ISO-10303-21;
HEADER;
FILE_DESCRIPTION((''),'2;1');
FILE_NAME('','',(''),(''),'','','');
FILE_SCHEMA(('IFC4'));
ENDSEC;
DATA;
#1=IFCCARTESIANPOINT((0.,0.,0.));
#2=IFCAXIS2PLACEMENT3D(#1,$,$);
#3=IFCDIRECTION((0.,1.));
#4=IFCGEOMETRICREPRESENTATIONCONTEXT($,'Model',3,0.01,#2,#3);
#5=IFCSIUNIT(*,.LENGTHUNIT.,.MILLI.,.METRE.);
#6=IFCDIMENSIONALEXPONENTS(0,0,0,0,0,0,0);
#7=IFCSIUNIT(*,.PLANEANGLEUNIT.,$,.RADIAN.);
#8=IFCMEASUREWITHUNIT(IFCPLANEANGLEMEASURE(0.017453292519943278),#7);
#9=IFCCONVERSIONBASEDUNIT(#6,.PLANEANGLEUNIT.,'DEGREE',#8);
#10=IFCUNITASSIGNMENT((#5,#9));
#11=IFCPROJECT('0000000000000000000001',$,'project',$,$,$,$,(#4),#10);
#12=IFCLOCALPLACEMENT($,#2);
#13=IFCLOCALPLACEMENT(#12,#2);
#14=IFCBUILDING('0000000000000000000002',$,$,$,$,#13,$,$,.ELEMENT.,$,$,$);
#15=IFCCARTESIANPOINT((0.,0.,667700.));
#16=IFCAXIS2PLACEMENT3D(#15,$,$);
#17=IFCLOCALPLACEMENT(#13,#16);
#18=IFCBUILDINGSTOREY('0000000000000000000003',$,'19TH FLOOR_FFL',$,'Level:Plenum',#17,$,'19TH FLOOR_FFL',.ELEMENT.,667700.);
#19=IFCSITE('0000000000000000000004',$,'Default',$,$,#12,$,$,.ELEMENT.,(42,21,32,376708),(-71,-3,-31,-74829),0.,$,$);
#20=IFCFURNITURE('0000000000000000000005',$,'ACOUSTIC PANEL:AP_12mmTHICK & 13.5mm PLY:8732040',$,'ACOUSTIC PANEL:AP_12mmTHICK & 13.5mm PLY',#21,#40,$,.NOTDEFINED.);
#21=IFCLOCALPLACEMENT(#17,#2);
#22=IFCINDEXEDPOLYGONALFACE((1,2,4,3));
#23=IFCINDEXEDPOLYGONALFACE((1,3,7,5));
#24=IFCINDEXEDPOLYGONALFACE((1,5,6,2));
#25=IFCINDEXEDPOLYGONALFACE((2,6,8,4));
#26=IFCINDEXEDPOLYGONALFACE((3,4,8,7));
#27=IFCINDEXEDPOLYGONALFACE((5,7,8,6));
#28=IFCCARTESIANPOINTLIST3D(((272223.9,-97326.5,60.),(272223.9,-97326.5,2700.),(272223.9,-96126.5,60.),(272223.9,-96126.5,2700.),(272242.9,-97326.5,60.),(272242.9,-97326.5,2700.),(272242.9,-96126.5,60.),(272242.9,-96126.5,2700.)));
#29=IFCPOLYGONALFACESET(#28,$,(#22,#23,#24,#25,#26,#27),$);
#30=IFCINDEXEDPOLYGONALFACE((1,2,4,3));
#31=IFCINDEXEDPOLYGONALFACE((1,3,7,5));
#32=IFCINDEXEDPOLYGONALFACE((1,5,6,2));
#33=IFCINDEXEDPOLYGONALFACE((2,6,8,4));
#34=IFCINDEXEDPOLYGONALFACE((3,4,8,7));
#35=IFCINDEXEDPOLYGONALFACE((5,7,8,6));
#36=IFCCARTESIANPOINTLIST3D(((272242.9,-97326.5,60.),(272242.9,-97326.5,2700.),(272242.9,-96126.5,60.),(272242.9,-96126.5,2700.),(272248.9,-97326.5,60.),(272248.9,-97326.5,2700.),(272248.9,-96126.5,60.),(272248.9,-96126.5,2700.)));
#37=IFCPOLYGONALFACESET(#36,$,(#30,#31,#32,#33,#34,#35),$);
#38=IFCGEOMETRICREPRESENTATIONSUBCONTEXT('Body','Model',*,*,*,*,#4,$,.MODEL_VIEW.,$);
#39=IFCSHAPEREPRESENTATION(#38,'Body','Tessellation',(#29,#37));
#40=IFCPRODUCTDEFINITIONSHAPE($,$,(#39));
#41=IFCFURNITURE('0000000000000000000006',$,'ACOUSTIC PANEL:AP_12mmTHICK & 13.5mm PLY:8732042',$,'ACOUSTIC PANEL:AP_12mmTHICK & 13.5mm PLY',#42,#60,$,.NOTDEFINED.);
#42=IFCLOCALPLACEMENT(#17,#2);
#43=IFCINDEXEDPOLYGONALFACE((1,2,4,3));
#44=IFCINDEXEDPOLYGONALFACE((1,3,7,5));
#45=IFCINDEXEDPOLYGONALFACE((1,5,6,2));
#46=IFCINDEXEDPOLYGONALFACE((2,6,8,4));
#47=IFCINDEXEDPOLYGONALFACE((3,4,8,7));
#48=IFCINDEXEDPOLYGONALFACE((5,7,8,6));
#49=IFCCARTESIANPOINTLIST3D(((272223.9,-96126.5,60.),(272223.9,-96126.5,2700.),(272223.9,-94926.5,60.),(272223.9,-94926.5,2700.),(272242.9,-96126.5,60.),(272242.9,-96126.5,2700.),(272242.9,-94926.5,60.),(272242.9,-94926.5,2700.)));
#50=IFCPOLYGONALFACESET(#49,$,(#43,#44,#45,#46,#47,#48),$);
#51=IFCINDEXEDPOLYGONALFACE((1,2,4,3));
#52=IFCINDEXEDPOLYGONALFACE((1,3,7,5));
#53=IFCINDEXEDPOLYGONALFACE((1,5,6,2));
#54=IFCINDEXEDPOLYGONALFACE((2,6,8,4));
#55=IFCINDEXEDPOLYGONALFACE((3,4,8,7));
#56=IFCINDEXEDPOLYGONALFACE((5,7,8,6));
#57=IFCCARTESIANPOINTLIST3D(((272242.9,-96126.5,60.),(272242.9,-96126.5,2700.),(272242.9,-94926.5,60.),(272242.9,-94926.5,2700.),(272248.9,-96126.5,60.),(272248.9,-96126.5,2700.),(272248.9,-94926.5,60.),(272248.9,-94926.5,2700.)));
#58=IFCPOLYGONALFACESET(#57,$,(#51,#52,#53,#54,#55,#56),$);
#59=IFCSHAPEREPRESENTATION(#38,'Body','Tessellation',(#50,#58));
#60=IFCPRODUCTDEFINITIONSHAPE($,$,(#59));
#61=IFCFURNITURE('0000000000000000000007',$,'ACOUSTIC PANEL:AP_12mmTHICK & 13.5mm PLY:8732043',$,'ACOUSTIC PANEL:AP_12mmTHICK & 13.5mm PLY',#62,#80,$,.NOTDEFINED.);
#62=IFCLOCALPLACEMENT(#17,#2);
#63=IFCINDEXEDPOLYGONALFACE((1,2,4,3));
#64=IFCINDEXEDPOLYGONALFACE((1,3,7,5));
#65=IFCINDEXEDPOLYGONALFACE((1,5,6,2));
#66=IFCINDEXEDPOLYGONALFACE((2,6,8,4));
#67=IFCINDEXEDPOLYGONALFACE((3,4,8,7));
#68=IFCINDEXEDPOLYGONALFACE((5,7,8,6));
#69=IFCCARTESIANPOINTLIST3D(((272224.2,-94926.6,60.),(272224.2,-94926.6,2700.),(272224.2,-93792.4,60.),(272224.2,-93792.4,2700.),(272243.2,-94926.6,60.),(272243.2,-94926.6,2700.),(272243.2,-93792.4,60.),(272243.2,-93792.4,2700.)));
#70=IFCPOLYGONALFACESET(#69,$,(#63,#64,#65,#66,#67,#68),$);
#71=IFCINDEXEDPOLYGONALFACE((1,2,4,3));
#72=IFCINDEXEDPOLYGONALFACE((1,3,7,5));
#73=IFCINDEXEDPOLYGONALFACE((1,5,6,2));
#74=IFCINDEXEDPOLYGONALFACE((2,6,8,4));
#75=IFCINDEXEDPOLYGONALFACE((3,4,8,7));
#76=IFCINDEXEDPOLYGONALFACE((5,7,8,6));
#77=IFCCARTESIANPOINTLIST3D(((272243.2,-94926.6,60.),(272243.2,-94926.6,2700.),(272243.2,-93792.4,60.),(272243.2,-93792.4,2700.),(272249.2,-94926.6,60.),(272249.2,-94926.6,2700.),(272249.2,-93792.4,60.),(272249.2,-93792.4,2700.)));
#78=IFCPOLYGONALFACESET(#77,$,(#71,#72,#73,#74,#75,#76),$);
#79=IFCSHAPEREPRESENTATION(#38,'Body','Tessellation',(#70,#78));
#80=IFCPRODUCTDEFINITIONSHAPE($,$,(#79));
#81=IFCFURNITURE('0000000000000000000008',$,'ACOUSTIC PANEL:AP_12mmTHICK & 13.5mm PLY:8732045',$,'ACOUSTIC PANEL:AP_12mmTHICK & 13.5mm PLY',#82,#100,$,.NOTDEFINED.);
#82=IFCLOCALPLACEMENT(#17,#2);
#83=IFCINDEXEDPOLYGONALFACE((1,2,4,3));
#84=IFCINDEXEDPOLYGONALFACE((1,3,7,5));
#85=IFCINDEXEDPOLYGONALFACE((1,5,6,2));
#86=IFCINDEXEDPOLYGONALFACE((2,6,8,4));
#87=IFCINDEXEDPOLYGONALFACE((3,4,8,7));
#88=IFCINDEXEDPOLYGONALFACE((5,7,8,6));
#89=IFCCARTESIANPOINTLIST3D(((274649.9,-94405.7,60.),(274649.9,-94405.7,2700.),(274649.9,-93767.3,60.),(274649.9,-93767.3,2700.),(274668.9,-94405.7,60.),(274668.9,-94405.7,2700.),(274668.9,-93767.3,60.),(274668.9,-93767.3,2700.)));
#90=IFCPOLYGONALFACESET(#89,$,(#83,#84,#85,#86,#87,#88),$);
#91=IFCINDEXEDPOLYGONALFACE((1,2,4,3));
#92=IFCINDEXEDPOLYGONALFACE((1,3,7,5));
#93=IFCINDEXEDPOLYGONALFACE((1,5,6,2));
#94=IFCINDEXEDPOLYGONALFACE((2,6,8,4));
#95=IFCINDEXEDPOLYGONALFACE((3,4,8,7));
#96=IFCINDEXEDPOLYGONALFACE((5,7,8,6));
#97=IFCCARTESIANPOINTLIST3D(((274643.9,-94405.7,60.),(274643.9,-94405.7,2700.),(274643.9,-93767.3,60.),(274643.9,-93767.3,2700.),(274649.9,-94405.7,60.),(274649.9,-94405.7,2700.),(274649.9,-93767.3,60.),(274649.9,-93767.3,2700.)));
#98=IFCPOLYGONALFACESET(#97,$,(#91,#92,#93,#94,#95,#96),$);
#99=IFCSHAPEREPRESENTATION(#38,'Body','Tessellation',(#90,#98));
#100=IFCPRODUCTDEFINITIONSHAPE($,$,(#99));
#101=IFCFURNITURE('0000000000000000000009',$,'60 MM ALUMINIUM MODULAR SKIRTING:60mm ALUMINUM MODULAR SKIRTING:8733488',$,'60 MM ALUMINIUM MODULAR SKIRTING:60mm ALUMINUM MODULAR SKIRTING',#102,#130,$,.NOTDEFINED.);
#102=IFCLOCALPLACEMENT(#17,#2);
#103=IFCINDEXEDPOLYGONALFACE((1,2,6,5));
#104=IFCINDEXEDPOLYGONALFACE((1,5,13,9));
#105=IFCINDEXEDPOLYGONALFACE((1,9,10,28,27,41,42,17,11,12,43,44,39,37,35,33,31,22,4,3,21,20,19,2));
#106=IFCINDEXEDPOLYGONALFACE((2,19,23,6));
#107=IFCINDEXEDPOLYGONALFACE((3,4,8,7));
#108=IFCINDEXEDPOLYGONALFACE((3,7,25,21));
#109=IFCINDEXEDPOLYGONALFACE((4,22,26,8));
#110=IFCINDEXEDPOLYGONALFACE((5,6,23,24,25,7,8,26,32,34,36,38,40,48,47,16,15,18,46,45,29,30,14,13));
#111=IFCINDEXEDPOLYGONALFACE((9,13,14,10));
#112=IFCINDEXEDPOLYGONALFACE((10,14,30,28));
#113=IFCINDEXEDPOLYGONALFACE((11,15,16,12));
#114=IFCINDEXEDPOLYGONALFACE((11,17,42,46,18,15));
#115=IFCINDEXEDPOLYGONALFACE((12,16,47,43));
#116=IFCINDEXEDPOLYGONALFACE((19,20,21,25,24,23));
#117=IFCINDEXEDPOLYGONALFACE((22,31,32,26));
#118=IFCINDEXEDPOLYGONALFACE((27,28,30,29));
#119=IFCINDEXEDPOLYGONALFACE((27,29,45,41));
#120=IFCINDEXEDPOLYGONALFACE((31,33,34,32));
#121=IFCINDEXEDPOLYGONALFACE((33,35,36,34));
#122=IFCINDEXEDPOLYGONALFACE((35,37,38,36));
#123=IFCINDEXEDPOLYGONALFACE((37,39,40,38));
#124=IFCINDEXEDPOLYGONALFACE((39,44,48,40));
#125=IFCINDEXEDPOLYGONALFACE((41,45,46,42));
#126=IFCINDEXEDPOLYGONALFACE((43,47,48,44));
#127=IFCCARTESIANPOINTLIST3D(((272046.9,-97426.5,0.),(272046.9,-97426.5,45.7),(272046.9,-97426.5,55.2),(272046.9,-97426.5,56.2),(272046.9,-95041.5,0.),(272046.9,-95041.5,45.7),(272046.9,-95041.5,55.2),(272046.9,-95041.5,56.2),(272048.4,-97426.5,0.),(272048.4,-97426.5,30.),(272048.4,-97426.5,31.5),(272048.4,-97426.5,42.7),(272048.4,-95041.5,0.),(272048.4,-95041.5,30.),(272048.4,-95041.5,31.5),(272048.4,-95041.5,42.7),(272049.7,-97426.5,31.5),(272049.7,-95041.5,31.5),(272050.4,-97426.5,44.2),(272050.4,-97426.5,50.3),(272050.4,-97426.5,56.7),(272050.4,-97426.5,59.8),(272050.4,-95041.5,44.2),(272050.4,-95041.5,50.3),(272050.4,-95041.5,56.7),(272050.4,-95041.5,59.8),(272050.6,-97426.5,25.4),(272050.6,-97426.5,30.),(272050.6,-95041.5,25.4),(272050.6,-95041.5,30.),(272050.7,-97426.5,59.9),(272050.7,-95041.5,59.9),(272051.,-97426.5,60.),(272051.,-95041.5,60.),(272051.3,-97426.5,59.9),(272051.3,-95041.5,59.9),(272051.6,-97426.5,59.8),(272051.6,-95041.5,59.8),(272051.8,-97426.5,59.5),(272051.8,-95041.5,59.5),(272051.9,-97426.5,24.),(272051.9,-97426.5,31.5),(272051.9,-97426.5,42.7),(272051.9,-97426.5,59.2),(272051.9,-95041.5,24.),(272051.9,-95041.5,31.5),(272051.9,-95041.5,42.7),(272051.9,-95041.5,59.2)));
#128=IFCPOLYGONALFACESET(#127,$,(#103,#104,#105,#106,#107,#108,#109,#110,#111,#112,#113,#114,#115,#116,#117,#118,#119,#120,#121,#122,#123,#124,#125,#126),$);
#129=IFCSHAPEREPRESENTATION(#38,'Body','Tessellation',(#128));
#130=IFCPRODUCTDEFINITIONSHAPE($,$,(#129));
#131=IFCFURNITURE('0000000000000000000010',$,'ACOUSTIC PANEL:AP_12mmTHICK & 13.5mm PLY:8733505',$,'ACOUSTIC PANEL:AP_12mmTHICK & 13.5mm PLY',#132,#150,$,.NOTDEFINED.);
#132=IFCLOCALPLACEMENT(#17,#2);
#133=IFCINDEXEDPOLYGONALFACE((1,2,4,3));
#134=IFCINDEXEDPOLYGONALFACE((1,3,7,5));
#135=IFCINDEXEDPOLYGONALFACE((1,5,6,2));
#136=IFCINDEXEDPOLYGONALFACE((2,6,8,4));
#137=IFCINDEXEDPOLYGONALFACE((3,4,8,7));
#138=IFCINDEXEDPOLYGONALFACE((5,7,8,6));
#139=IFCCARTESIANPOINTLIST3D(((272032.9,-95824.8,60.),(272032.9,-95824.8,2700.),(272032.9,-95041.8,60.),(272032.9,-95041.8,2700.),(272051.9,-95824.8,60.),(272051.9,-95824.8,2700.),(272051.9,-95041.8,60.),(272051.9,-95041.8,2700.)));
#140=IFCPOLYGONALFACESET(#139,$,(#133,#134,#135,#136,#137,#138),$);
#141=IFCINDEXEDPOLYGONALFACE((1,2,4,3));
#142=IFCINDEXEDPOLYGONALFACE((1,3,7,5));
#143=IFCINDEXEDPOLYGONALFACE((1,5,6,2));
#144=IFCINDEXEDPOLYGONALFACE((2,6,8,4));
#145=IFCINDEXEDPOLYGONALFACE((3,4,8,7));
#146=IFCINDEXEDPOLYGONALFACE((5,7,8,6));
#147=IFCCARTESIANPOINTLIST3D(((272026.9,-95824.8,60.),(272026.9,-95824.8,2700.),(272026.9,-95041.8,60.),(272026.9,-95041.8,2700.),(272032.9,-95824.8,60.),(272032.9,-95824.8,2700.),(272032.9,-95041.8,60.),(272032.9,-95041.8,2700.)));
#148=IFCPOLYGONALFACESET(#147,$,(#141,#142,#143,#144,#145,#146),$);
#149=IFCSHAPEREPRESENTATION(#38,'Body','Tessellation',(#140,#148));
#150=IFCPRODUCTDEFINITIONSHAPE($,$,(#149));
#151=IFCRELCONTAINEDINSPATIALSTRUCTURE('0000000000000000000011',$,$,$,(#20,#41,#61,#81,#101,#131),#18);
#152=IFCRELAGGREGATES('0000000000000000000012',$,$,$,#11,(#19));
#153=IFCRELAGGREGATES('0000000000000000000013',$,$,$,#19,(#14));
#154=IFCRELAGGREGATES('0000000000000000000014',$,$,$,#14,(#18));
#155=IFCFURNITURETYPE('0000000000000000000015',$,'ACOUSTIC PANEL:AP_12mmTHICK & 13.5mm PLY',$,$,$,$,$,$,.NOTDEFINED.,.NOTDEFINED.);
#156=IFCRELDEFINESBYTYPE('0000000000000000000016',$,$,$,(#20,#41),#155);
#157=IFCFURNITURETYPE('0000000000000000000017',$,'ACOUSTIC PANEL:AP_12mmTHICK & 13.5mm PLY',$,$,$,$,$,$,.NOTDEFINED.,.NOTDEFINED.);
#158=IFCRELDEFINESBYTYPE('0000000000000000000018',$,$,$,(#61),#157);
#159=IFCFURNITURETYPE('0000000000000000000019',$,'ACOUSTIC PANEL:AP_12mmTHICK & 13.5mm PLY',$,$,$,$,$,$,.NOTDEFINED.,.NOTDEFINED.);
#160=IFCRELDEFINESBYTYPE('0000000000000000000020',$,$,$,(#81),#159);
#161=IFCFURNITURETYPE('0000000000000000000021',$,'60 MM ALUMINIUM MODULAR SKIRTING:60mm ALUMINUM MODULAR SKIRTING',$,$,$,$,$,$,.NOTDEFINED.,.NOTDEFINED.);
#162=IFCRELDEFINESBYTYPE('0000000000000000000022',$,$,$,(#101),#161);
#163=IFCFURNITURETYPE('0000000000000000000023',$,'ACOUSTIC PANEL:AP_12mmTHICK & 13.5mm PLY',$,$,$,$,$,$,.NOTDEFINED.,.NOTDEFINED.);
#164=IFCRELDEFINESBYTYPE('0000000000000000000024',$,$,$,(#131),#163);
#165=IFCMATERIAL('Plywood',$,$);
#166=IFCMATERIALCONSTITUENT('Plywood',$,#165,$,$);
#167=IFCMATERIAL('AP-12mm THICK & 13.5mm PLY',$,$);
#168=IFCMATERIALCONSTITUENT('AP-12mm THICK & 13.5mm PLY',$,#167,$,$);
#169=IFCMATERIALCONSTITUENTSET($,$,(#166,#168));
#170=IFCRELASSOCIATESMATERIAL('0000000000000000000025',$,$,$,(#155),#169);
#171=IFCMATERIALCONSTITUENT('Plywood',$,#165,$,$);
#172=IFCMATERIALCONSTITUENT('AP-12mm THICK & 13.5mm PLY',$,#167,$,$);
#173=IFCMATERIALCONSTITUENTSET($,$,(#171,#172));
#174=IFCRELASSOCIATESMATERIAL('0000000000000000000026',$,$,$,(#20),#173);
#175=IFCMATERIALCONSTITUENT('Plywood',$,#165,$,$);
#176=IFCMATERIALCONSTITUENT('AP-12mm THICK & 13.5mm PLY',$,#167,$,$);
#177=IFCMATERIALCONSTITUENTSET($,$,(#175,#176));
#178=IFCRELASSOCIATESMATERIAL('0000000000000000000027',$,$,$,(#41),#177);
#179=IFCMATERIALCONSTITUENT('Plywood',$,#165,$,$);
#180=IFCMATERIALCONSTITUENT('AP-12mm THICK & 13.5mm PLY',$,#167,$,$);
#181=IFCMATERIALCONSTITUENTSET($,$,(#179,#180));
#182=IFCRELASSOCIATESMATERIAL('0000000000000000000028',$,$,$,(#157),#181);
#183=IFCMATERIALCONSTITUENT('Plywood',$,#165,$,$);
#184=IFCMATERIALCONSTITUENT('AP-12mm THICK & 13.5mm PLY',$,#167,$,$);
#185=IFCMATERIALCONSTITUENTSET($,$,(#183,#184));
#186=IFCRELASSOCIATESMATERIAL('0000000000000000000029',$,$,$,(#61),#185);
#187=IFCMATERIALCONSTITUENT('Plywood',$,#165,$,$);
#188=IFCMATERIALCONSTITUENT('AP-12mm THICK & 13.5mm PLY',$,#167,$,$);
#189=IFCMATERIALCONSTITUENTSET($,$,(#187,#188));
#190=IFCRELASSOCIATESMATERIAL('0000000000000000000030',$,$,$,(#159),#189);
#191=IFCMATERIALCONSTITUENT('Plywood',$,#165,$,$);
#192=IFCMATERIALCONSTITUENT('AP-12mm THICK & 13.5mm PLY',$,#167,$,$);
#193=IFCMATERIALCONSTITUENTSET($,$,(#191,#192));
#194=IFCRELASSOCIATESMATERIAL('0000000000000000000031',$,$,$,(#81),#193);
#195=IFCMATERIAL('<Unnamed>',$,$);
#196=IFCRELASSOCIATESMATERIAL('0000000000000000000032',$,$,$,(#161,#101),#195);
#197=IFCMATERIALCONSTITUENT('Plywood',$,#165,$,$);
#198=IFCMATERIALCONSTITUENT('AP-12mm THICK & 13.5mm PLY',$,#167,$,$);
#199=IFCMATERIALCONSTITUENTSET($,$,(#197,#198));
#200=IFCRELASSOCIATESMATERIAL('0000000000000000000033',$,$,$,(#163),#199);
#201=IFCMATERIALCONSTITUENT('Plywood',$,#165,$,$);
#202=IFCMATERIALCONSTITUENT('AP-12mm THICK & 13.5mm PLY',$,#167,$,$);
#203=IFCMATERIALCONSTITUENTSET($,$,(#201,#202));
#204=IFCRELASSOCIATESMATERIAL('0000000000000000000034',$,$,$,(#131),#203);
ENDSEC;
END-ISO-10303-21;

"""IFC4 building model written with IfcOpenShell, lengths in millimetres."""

from ifc_helpers import new_model, entity, si_unit, converted_unit, direction, frame, origin, place, context, subcontext, project, spatial, line, arc, indexed_curve, outline, extrude, source, transform, mapped, material, constituent, constituent_set, type_object, type_shapes, element, save


model = new_model("IFC4")

# Units and contexts
model_context = context("Model", 3, precision=0.01, world=origin(), true_north=direction((0.0, 1.0)))
body_context = subcontext(model_context, "Body", "Model", "MODEL_VIEW")
ifc_project = project(units=[si_unit("LENGTHUNIT", "METRE", prefix="MILLI"), converted_unit("PLANEANGLEUNIT", "DEGREE", entity("IfcPlaneAngleMeasure", 0.017453292519943278), si_unit("PLANEANGLEUNIT", "RADIAN"), dimensions=[0, 0, 0, 0, 0, 0, 0])], contexts=[model_context])

# Site, building, storey
site_placement = place(None, origin())
site = spatial("IfcSite", under=ifc_project, at=site_placement, Name="Default", CompositionType="ELEMENT", RefLatitude=(42, 21, 32, 376708), RefLongitude=(-71, -3, -31, -74829), RefElevation=0.0)
building_placement = place(site_placement, origin())
building = spatial("IfcBuilding", under=site, at=building_placement, CompositionType="ELEMENT")
storey_placement = place(building_placement, frame((0.0, 0.0, 667700.0)))
storey = spatial("IfcBuildingStorey", under=building, at=storey_placement, Name="19TH FLOOR_FFL", ObjectType="Level:Plenum", LongName="19TH FLOOR_FFL", CompositionType="ELEMENT", Elevation=667700.0)

# Shared definitions
ifc_material_1 = material(Name="<Unnamed>")

# Furniture
ifc_material_2 = material(Name="Plywood")
ifc_constituent_1 = constituent(ifc_material_2, Name="Plywood")
ifc_material_3 = material(Name="AP-12mm THICK & 13.5mm PLY")
ifc_constituent_2 = constituent(ifc_material_3, Name="AP-12mm THICK & 13.5mm PLY")
ifc_constituent_set_1 = constituent_set(constituents=[ifc_constituent_1, ifc_constituent_2])
ifc_constituent_3 = constituent(ifc_material_2, Name="Plywood")
ifc_constituent_4 = constituent(ifc_material_3, Name="AP-12mm THICK & 13.5mm PLY")
ifc_constituent_set_2 = constituent_set(constituents=[ifc_constituent_3, ifc_constituent_4])
furniture_type_1 = type_object("IfcFurnitureType", Name="ACOUSTIC PANEL:AP_12mmTHICK & 13.5mm PLY", AssemblyPlace="NOTDEFINED", PredefinedType="NOTDEFINED", material=ifc_constituent_set_2)
shared_shape_1 = source(origin(), body_context, "Body", "SweptSolid", [
    extrude(outline(indexed_curve([(-600.0, -1320.0), (600.0, -1320.0), (600.0, 1320.0), (-600.0, 1320.0), (-600.0, -1320.0)], self_intersect=False)), frame((0.0, 1320.0, 0.0), z_axis=(0.0, 0.0, 1.0), x_axis=(-1.0, 0.0, 0.0)), (0.0, 0.0, 1.0), 19.0),
    extrude(outline(indexed_curve([(-600.0, -1320.0), (600.0, -1320.0), (600.0, 1320.0), (-600.0, 1320.0), (-600.0, -1320.0)], self_intersect=False)), frame((0.0, 1320.0, 19.0), z_axis=(0.0, 0.0, 1.0), x_axis=(-1.0, 0.0, 0.0)), (0.0, 0.0, 1.0), 6.0),
])
type_shapes(furniture_type_1, [shared_shape_1])
furniture_1_placement = place(storey_placement, frame((272223.9, -96726.5, 60.0), z_axis=(1.0, 0.0, 0.0), x_axis=(0.0, 1.0, 0.0)))
element("IfcFurniture", 1, at=furniture_1_placement, inside=storey, type_object=furniture_type_1, material=ifc_constituent_set_1, Name="ACOUSTIC PANEL:AP_12mmTHICK & 13.5mm PLY:8732040", ObjectType="ACOUSTIC PANEL:AP_12mmTHICK & 13.5mm PLY", PredefinedType="NOTDEFINED", context=body_context, shape_type="MappedRepresentation", body=[
    mapped(shared_shape_1, transform((0.0, 0.0, 0.0), scale=1.0)),
])
ifc_constituent_5 = constituent(ifc_material_2, Name="Plywood")
ifc_constituent_6 = constituent(ifc_material_3, Name="AP-12mm THICK & 13.5mm PLY")
ifc_constituent_set_3 = constituent_set(constituents=[ifc_constituent_5, ifc_constituent_6])
furniture_2_placement = place(storey_placement, frame((272223.9, -95526.5, 60.0), z_axis=(1.0, 0.0, 0.0), x_axis=(0.0, 1.0, 0.0)))
element("IfcFurniture", 2, at=furniture_2_placement, inside=storey, type_object=furniture_type_1, material=ifc_constituent_set_3, Name="ACOUSTIC PANEL:AP_12mmTHICK & 13.5mm PLY:8732042", ObjectType="ACOUSTIC PANEL:AP_12mmTHICK & 13.5mm PLY", PredefinedType="NOTDEFINED", context=body_context, shape_type="MappedRepresentation", body=[
    mapped(shared_shape_1, transform((0.0, 0.0, 0.0), scale=1.0)),
])
ifc_constituent_7 = constituent(ifc_material_2, Name="Plywood")
ifc_constituent_8 = constituent(ifc_material_3, Name="AP-12mm THICK & 13.5mm PLY")
ifc_constituent_set_4 = constituent_set(constituents=[ifc_constituent_7, ifc_constituent_8])
ifc_constituent_9 = constituent(ifc_material_2, Name="Plywood")
ifc_constituent_10 = constituent(ifc_material_3, Name="AP-12mm THICK & 13.5mm PLY")
ifc_constituent_set_5 = constituent_set(constituents=[ifc_constituent_9, ifc_constituent_10])
furniture_type_2 = type_object("IfcFurnitureType", Name="ACOUSTIC PANEL:AP_12mmTHICK & 13.5mm PLY", AssemblyPlace="NOTDEFINED", PredefinedType="NOTDEFINED", material=ifc_constituent_set_5)
shared_shape_2 = source(origin(), body_context, "Body", "SweptSolid", [
    extrude(outline(indexed_curve([(-567.1, -1320.0), (567.1, -1320.0), (567.1, 1320.0), (-567.1, 1320.0), (-567.1, -1320.0)], self_intersect=False)), frame((0.0, 1320.0, 0.0), z_axis=(0.0, 0.0, 1.0), x_axis=(-1.0, 0.0, 0.0)), (0.0, 0.0, 1.0), 19.0),
    extrude(outline(indexed_curve([(-567.1, -1320.0), (567.1, -1320.0), (567.1, 1320.0), (-567.1, 1320.0), (-567.1, -1320.0)], self_intersect=False)), frame((0.0, 1320.0, 19.0), z_axis=(0.0, 0.0, 1.0), x_axis=(-1.0, 0.0, 0.0)), (0.0, 0.0, 1.0), 6.0),
])
type_shapes(furniture_type_2, [shared_shape_2])
furniture_3_placement = place(storey_placement, frame((272224.2, -94359.5, 60.0), z_axis=(1.0, 0.0, 0.0), x_axis=(0.0, 1.0, 0.0)))
element("IfcFurniture", 3, at=furniture_3_placement, inside=storey, type_object=furniture_type_2, material=ifc_constituent_set_4, Name="ACOUSTIC PANEL:AP_12mmTHICK & 13.5mm PLY:8732043", ObjectType="ACOUSTIC PANEL:AP_12mmTHICK & 13.5mm PLY", PredefinedType="NOTDEFINED", context=body_context, shape_type="MappedRepresentation", body=[
    mapped(shared_shape_2, transform((0.0, 0.0, 0.0), scale=1.0)),
])
ifc_constituent_11 = constituent(ifc_material_2, Name="Plywood")
ifc_constituent_12 = constituent(ifc_material_3, Name="AP-12mm THICK & 13.5mm PLY")
ifc_constituent_set_6 = constituent_set(constituents=[ifc_constituent_11, ifc_constituent_12])
ifc_constituent_13 = constituent(ifc_material_2, Name="Plywood")
ifc_constituent_14 = constituent(ifc_material_3, Name="AP-12mm THICK & 13.5mm PLY")
ifc_constituent_set_7 = constituent_set(constituents=[ifc_constituent_13, ifc_constituent_14])
furniture_type_3 = type_object("IfcFurnitureType", Name="ACOUSTIC PANEL:AP_12mmTHICK & 13.5mm PLY", AssemblyPlace="NOTDEFINED", PredefinedType="NOTDEFINED", material=ifc_constituent_set_7)
shared_shape_3 = source(origin(), body_context, "Body", "SweptSolid", [
    extrude(outline(indexed_curve([(-319.2, -1320.0), (319.2, -1320.0), (319.2, 1320.0), (-319.2, 1320.0), (-319.2, -1320.0)], self_intersect=False)), frame((0.0, 1320.0, 0.0), z_axis=(0.0, 0.0, 1.0), x_axis=(-1.0, 0.0, 0.0)), (0.0, 0.0, 1.0), 19.0),
    extrude(outline(indexed_curve([(-319.2, -1320.0), (319.2, -1320.0), (319.2, 1320.0), (-319.2, 1320.0), (-319.2, -1320.0)], self_intersect=False)), frame((0.0, 1320.0, 19.0), z_axis=(0.0, 0.0, 1.0), x_axis=(-1.0, 0.0, 0.0)), (0.0, 0.0, 1.0), 6.0),
])
type_shapes(furniture_type_3, [shared_shape_3])
furniture_4_placement = place(storey_placement, frame((274668.9, -94086.5, 60.0), z_axis=(-1.0, 0.0, 0.0), x_axis=(0.0, -1.0, 0.0)))
element("IfcFurniture", 4, at=furniture_4_placement, inside=storey, type_object=furniture_type_3, material=ifc_constituent_set_6, Name="ACOUSTIC PANEL:AP_12mmTHICK & 13.5mm PLY:8732045", ObjectType="ACOUSTIC PANEL:AP_12mmTHICK & 13.5mm PLY", PredefinedType="NOTDEFINED", context=body_context, shape_type="MappedRepresentation", body=[
    mapped(shared_shape_3, transform((0.0, 0.0, 0.0), scale=1.0)),
])
furniture_type_4 = type_object("IfcFurnitureType", Name="60 MM ALUMINIUM MODULAR SKIRTING:60mm ALUMINUM MODULAR SKIRTING", AssemblyPlace="NOTDEFINED", PredefinedType="NOTDEFINED", material=ifc_material_1)
shared_shape_4 = source(origin(), body_context, "Body", "SweptSolid", [
    extrude(outline(indexed_curve([(-18.5, -2.7), (-17.5, -2.7), (-19.0, 0.8), (-12.6, 0.8), (-6.5, 0.8), (-8.0, -2.7), (37.7, -2.7), (37.7, -1.2), (7.7, -1.2), (7.7, 1.0), (12.3, 1.0), (13.7, 2.4), (6.2, 2.4), (6.2, 0.2), (6.2, -1.2), (-5.0, -1.2), (-5.0, 2.4), (-21.4, 2.3), (-22.2, 1.8), (-22.0, 0.9)], segments=[line(1, 2, 3, 4, 5, 6, 7, 8, 9, 10, 11, 12, 13, 14, 15, 16, 17, 18), arc(18, 19, 20), line(20, 1)], self_intersect=False)), frame((0.0, -2.4, 37.7), z_axis=(1.0, 0.0, 0.0), x_axis=(0.0, 0.0, -1.0)), (0.0, 0.0, 1.0), 2385.0),
])
type_shapes(furniture_type_4, [shared_shape_4])
furniture_5_placement = place(storey_placement, frame((272051.9, -95041.5, 0.0), z_axis=(0.0, 0.0, 1.0), x_axis=(0.0, -1.0, 0.0)))
element("IfcFurniture", 5, at=furniture_5_placement, inside=storey, type_object=furniture_type_4, material=ifc_material_1, Name="60 MM ALUMINIUM MODULAR SKIRTING:60mm ALUMINUM MODULAR SKIRTING:8733488", ObjectType="60 MM ALUMINIUM MODULAR SKIRTING:60mm ALUMINUM MODULAR SKIRTING", PredefinedType="NOTDEFINED", context=body_context, shape_type="MappedRepresentation", body=[
    mapped(shared_shape_4, transform((0.0, 0.0, 0.0), scale=1.0)),
])
ifc_constituent_15 = constituent(ifc_material_2, Name="Plywood")
ifc_constituent_16 = constituent(ifc_material_3, Name="AP-12mm THICK & 13.5mm PLY")
ifc_constituent_set_8 = constituent_set(constituents=[ifc_constituent_15, ifc_constituent_16])
ifc_constituent_17 = constituent(ifc_material_2, Name="Plywood")
ifc_constituent_18 = constituent(ifc_material_3, Name="AP-12mm THICK & 13.5mm PLY")
ifc_constituent_set_9 = constituent_set(constituents=[ifc_constituent_17, ifc_constituent_18])
furniture_type_5 = type_object("IfcFurnitureType", Name="ACOUSTIC PANEL:AP_12mmTHICK & 13.5mm PLY", AssemblyPlace="NOTDEFINED", PredefinedType="NOTDEFINED", material=ifc_constituent_set_9)
shared_shape_5 = source(origin(), body_context, "Body", "SweptSolid", [
    extrude(outline(indexed_curve([(-391.5, -1320.0), (391.5, -1320.0), (391.5, 1320.0), (-391.5, 1320.0), (-391.5, -1320.0)], self_intersect=False)), frame((0.0, 1320.0, 0.0), z_axis=(0.0, 0.0, 1.0), x_axis=(-1.0, 0.0, 0.0)), (0.0, 0.0, 1.0), 19.0),
    extrude(outline(indexed_curve([(-391.5, -1320.0), (391.5, -1320.0), (391.5, 1320.0), (-391.5, 1320.0), (-391.5, -1320.0)], self_intersect=False)), frame((0.0, 1320.0, 19.0), z_axis=(0.0, 0.0, 1.0), x_axis=(-1.0, 0.0, 0.0)), (0.0, 0.0, 1.0), 6.0),
])
type_shapes(furniture_type_5, [shared_shape_5])
furniture_6_placement = place(storey_placement, frame((272051.9, -95433.3, 60.0), z_axis=(-1.0, 0.0, 0.0), x_axis=(0.0, -1.0, 0.0)))
element("IfcFurniture", 6, at=furniture_6_placement, inside=storey, type_object=furniture_type_5, material=ifc_constituent_set_8, Name="ACOUSTIC PANEL:AP_12mmTHICK & 13.5mm PLY:8733505", ObjectType="ACOUSTIC PANEL:AP_12mmTHICK & 13.5mm PLY", PredefinedType="NOTDEFINED", context=body_context, shape_type="MappedRepresentation", body=[
    mapped(shared_shape_5, transform((0.0, 0.0, 0.0), scale=1.0)),
])

save(model, "model.ifc")
